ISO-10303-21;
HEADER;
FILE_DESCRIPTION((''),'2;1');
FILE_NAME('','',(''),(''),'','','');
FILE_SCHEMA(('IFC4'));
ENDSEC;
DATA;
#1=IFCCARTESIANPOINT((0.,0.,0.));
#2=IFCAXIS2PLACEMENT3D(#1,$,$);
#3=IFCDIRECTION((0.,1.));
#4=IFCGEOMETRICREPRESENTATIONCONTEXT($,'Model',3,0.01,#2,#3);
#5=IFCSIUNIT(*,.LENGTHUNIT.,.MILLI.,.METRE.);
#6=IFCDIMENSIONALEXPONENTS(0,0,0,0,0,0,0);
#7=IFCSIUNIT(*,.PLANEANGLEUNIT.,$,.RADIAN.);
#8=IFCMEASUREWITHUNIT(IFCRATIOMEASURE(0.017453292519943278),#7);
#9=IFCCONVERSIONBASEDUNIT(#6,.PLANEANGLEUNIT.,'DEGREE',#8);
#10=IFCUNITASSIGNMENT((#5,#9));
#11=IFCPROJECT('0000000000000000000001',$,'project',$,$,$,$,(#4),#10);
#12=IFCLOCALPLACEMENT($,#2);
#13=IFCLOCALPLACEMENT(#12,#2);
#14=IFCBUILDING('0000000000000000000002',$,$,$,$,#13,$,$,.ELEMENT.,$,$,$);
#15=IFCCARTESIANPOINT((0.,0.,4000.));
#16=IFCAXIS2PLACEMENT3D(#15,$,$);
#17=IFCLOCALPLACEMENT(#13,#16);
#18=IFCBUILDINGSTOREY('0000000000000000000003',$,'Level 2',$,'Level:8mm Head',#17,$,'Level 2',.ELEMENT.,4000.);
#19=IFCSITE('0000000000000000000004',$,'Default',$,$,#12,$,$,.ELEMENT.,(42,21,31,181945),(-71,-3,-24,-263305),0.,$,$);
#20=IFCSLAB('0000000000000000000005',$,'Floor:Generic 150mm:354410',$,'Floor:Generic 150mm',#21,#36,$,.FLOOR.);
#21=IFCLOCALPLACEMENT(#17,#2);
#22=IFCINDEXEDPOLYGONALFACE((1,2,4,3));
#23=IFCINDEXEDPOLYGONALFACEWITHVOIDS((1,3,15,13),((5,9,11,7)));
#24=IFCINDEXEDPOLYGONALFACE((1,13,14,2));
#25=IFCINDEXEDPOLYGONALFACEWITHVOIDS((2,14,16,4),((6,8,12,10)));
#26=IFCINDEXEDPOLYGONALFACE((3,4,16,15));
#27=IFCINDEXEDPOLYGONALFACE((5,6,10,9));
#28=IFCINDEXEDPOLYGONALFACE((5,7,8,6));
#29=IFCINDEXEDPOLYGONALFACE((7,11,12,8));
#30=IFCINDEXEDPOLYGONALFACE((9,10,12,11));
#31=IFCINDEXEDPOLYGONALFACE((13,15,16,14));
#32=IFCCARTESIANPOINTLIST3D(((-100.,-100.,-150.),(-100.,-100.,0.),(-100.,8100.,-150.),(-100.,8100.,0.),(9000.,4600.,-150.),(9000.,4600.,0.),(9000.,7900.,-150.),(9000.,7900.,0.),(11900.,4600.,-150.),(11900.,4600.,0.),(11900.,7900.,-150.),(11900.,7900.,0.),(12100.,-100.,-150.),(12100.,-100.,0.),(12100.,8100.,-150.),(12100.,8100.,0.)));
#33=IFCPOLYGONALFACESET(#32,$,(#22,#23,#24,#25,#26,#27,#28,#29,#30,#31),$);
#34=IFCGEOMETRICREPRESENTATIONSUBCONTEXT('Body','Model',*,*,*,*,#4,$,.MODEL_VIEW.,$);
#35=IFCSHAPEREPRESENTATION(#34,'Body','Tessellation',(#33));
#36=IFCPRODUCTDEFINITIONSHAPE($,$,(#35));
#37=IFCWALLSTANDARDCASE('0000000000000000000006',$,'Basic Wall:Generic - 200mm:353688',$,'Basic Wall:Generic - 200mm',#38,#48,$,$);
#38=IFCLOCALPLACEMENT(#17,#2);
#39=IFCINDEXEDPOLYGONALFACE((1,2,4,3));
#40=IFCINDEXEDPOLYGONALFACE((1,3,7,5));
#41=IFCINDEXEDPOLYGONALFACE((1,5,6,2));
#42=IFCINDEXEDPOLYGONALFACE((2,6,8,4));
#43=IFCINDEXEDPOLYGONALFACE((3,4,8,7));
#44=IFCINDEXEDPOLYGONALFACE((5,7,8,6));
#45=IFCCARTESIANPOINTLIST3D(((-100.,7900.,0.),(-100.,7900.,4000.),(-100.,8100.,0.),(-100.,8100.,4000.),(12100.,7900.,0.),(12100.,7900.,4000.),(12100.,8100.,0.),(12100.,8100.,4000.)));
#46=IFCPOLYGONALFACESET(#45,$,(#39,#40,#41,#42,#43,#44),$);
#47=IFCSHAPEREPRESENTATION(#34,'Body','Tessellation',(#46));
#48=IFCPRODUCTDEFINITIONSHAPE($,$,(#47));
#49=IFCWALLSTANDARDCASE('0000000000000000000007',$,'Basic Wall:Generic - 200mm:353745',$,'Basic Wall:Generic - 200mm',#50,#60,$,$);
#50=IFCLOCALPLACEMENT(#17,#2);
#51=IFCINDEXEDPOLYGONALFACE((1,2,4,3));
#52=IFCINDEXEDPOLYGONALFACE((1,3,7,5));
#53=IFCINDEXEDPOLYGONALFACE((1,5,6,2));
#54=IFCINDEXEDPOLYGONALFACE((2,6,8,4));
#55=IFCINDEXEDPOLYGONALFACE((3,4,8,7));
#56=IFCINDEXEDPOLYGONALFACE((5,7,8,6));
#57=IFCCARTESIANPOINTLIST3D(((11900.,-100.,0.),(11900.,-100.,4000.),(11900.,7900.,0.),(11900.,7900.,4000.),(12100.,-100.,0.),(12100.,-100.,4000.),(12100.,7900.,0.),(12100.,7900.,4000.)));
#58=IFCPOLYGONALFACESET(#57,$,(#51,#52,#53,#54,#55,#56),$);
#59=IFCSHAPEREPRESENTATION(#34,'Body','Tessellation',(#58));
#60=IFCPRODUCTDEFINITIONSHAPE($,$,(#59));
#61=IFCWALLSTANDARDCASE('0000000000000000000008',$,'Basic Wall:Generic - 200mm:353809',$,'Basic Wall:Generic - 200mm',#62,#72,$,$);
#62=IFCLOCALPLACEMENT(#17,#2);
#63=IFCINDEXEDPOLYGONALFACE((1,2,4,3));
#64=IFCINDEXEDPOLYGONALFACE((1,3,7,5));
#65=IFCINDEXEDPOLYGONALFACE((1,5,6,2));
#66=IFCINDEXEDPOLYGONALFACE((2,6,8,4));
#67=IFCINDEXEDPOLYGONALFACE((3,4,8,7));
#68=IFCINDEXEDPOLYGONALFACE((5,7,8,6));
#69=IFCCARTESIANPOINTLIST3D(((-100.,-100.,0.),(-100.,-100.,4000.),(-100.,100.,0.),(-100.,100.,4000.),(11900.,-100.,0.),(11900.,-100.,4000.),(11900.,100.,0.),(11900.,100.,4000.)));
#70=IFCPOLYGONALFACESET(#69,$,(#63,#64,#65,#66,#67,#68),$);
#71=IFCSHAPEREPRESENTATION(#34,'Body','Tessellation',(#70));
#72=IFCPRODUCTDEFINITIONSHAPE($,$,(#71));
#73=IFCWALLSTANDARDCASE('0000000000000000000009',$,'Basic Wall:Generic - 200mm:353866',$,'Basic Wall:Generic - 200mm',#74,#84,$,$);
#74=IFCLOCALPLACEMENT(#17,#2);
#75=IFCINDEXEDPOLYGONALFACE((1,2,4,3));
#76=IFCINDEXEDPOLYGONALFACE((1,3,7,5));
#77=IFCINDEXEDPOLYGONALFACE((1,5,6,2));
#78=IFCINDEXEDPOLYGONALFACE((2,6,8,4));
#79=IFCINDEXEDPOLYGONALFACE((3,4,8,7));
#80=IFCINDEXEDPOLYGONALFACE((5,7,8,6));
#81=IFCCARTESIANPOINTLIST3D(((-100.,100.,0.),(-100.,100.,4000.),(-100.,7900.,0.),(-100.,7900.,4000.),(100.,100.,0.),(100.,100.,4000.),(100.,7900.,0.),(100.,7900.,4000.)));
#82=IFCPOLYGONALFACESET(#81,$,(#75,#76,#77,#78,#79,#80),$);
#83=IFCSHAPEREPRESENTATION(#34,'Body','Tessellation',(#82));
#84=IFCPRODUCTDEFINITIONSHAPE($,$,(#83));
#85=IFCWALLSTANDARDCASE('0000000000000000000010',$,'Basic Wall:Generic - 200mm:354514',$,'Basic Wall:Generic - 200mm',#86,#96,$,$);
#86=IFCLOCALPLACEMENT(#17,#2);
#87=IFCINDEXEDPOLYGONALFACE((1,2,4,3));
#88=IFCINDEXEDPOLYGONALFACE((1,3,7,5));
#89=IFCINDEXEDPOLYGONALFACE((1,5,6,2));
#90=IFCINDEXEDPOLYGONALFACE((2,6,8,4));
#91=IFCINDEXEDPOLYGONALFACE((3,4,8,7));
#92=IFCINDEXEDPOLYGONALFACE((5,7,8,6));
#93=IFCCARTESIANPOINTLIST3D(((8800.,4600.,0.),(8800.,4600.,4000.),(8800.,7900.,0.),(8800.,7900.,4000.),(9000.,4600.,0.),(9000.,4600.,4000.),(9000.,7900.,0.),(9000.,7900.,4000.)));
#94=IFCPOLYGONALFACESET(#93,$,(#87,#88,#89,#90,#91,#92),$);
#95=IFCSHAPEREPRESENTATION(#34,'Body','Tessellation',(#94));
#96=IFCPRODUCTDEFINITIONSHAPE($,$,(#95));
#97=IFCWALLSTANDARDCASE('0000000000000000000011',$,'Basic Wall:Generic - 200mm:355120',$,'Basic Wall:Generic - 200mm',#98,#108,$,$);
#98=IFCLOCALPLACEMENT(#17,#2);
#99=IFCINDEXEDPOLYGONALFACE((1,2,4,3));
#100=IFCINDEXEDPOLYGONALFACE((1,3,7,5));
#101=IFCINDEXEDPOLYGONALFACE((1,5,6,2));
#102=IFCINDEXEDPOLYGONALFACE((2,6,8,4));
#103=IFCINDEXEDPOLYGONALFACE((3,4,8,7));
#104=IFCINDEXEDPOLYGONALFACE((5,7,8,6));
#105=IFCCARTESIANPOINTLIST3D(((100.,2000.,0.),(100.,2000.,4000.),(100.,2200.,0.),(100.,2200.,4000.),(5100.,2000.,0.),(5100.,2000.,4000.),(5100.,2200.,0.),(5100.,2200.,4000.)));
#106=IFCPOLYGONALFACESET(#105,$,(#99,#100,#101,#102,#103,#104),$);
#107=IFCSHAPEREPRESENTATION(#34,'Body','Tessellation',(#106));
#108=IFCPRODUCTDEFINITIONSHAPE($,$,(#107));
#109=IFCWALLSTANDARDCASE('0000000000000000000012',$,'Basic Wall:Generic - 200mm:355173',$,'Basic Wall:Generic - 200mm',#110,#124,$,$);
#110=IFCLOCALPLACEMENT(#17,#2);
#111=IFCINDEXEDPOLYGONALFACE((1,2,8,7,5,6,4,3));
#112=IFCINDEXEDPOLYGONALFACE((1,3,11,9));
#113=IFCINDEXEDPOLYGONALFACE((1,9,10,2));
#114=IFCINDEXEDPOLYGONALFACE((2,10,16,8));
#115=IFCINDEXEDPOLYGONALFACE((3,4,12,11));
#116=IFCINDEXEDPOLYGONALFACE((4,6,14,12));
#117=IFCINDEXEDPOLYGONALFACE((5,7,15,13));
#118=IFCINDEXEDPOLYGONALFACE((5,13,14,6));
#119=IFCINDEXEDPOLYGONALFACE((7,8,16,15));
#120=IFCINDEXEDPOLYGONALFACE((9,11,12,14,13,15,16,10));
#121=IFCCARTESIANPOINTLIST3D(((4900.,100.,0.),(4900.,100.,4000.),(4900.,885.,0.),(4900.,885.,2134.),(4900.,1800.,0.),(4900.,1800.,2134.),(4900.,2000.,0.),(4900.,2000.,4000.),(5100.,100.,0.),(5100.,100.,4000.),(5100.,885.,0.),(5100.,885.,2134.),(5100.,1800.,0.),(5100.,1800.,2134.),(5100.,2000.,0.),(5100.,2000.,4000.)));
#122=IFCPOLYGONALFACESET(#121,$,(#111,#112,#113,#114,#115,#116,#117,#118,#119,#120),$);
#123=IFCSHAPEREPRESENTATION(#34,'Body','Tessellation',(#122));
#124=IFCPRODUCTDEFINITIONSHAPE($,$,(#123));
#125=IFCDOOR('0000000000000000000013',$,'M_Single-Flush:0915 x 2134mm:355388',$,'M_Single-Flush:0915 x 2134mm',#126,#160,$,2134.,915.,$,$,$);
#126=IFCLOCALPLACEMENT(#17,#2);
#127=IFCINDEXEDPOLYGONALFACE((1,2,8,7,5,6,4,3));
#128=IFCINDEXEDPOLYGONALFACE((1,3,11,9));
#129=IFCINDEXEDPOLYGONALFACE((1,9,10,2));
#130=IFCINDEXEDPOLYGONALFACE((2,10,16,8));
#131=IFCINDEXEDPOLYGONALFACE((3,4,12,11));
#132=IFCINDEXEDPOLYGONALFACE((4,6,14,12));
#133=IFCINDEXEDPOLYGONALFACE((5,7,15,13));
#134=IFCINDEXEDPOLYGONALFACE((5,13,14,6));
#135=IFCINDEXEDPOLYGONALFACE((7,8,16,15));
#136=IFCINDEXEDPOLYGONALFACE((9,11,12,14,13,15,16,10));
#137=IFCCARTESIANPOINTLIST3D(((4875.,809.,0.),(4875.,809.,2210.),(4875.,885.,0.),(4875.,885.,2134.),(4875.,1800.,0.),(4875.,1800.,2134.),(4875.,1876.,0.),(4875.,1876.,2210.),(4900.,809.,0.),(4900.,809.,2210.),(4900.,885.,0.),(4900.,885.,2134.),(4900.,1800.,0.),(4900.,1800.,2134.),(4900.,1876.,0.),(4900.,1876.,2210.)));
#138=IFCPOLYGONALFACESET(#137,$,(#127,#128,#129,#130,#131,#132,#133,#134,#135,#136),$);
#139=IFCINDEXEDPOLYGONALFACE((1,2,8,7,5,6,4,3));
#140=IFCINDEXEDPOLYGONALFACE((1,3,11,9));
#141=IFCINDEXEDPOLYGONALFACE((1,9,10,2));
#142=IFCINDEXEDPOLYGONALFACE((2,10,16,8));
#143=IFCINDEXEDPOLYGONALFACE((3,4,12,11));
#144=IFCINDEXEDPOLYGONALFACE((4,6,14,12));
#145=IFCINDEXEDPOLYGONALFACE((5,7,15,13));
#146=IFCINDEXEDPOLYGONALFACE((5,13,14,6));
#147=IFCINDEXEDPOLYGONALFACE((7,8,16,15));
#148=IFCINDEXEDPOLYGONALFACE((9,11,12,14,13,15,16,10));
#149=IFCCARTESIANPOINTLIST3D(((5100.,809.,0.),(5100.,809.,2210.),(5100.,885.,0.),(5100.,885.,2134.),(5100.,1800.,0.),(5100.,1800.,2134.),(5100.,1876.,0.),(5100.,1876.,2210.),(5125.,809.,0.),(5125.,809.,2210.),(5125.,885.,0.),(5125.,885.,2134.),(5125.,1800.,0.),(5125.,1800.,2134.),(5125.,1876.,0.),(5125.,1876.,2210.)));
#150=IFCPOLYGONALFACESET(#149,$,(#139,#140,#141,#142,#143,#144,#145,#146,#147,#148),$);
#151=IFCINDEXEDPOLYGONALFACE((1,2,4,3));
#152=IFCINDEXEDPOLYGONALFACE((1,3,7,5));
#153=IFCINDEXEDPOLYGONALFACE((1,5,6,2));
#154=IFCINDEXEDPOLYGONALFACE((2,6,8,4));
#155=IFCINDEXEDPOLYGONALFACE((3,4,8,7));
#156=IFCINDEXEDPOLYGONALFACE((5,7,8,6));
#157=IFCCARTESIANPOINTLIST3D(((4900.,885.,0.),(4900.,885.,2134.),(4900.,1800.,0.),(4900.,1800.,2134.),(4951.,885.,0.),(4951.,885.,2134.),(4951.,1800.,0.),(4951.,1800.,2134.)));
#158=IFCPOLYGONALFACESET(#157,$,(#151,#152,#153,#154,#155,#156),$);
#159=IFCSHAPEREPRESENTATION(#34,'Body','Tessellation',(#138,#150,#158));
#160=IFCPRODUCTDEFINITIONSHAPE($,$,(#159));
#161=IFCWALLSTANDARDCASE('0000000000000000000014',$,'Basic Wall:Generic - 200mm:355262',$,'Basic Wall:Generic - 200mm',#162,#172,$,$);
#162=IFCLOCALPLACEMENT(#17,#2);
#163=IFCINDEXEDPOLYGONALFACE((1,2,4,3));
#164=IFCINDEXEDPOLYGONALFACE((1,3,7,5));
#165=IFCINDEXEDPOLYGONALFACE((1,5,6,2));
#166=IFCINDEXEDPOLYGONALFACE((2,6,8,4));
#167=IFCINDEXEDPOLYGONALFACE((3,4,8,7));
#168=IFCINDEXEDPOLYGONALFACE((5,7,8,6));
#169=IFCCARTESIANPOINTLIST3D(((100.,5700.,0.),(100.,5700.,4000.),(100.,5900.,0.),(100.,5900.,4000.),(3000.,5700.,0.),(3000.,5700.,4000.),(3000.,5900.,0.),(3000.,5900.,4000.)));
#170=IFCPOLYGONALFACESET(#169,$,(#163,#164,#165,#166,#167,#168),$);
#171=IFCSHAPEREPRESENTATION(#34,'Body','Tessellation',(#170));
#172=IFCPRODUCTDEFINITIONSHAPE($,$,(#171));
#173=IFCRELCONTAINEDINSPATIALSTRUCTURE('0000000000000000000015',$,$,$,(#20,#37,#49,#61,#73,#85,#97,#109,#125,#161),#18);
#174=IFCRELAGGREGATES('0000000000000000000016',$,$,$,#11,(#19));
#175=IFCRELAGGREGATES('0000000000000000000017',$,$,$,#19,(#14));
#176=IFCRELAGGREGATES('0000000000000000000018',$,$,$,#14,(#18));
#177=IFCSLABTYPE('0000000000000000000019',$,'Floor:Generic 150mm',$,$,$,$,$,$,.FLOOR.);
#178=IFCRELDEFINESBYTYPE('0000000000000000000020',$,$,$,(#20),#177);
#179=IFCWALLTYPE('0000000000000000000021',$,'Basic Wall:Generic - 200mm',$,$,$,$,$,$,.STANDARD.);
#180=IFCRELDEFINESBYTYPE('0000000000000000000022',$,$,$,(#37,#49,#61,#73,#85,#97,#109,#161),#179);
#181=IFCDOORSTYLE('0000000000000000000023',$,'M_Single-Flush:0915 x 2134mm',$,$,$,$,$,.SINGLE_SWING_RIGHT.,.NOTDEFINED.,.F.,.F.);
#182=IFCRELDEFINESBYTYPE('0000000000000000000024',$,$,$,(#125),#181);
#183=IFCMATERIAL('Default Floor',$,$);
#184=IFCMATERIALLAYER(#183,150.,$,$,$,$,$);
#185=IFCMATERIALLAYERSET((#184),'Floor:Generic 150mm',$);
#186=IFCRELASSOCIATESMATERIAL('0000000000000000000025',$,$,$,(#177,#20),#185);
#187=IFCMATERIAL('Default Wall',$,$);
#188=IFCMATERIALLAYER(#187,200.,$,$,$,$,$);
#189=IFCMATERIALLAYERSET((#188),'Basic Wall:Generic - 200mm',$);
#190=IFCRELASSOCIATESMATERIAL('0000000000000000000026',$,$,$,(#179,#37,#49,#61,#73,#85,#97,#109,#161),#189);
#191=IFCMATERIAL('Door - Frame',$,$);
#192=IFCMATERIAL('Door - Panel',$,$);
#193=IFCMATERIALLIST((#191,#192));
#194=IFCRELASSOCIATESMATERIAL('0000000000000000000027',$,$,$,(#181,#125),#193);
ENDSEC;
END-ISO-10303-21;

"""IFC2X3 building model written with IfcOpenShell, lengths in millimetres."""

from ifc_helpers import new_model, entity, si_unit, converted_unit, direction, frame, frame_2d, origin, place, context, subcontext, project, spatial, polyline, rectangle, outline, extrude, source, transform, mapped, material, material_list, layer, layer_set, layer_usage, type_object, type_shapes, element, fill, save


model = new_model("IFC2X3")

# Units and contexts
model_context = context("Model", 3, precision=0.01, world=origin(), true_north=direction((0.0, 1.0)))
body_context = subcontext(model_context, "Body", "Model", "MODEL_VIEW")
ifc_project = project(units=[si_unit("LENGTHUNIT", "METRE", prefix="MILLI"), converted_unit("PLANEANGLEUNIT", "DEGREE", entity("IfcRatioMeasure", 0.017453292519943278), si_unit("PLANEANGLEUNIT", "RADIAN"), dimensions=[0, 0, 0, 0, 0, 0, 0])], contexts=[model_context])

# Site, building, storey
site_placement = place(None, origin())
site = spatial("IfcSite", under=ifc_project, at=site_placement, Name="Default", CompositionType="ELEMENT", RefLatitude=(42, 21, 31, 181945), RefLongitude=(-71, -3, -24, -263305), RefElevation=0.0)
building_placement = place(site_placement, origin())
building = spatial("IfcBuilding", under=site, at=building_placement, CompositionType="ELEMENT")
storey_placement = place(building_placement, frame((0.0, 0.0, 4000.0)))
storey = spatial("IfcBuildingStorey", under=building, at=storey_placement, Name="Level 2", ObjectType="Level:8mm Head", LongName="Level 2", CompositionType="ELEMENT", Elevation=4000.0)

# Slab, opening
ifc_material_1 = material(Name="Default Floor")
ifc_layer_1 = layer(ifc_material_1, 150.0)
ifc_layer_set_1 = layer_set([ifc_layer_1], Name="Floor:Generic 150mm")
ifc_layer_usage_1 = layer_usage(ifc_layer_set_1, "AXIS3", "POSITIVE", 0.0)
slab_type = type_object("IfcSlabType", Name="Floor:Generic 150mm", PredefinedType="FLOOR", material=ifc_layer_set_1)
slab_placement = place(storey_placement, frame((-100.0, -100.0, -150.0)))
slab = element("IfcSlab", 1, at=slab_placement, inside=storey, type_object=slab_type, material=ifc_layer_usage_1, Name="Floor:Generic 150mm:354410", ObjectType="Floor:Generic 150mm", PredefinedType="FLOOR", context=body_context, shape_type="SweptSolid", body=[
    extrude(rectangle(XDim=8200.0, YDim=12200.0, at=frame_2d((0.0, 0.0), x_axis=(0.0, -1.0))), frame((6100.0, 4100.0, 150.0), z_axis=(0.0, 0.0, -1.0), x_axis=(-1.0, 0.0, 0.0)), (0.0, 0.0, 1.0), 150.0),
])
opening_1_placement = place(slab_placement, origin())
element("IfcOpeningElement", 2, at=opening_1_placement, cuts=slab, ObjectType="Opening", context=body_context, shape_type="SweptSolid", body=[
    extrude(rectangle(XDim=3300.0, YDim=2900.0, at=frame_2d((0.0, 0.0), x_axis=(1.0, 0.0))), frame((10550.0, 6350.0, 150.0), z_axis=(0.0, 0.0, -1.0), x_axis=(0.0, -1.0, 0.0)), (0.0, 0.0, 1.0), 150.0),
])

# Walls
ifc_material_2 = material(Name="Default Wall")
ifc_layer_2 = layer(ifc_material_2, 200.0)
ifc_layer_set_2 = layer_set([ifc_layer_2], Name="Basic Wall:Generic - 200mm")
ifc_layer_usage_2 = layer_usage(ifc_layer_set_2, "AXIS2", "NEGATIVE", 100.0)
wall_type = type_object("IfcWallType", Name="Basic Wall:Generic - 200mm", PredefinedType="STANDARD", material=ifc_layer_set_2)
wall_1_placement = place(storey_placement, frame((-100.0, 8000.0, 0.0)))
element("IfcWallStandardCase", 3, at=wall_1_placement, inside=storey, type_object=wall_type, material=ifc_layer_usage_2, Name="Basic Wall:Generic - 200mm:353688", ObjectType="Basic Wall:Generic - 200mm", context=body_context, shape_type="SweptSolid", body=[
    extrude(rectangle(XDim=12200.0, YDim=200.0, at=frame_2d((6100.0, 0.0), x_axis=(-1.0, 0.0))), origin(), (0.0, 0.0, 1.0), 4000.0),
])
wall_2_placement = place(storey_placement, frame((12000.0, 7900.0, 0.0), z_axis=(0.0, 0.0, 1.0), x_axis=(0.0, -1.0, 0.0)))
element("IfcWallStandardCase", 4, at=wall_2_placement, inside=storey, type_object=wall_type, material=ifc_layer_usage_2, Name="Basic Wall:Generic - 200mm:353745", ObjectType="Basic Wall:Generic - 200mm", context=body_context, shape_type="SweptSolid", body=[
    extrude(rectangle(XDim=8000.0, YDim=200.0, at=frame_2d((4000.0, 0.0), x_axis=(-1.0, 0.0))), origin(), (0.0, 0.0, 1.0), 4000.0),
])
wall_3_placement = place(storey_placement, frame((11900.0, 0.0, 0.0), z_axis=(0.0, 0.0, 1.0), x_axis=(-1.0, 0.0, 0.0)))
element("IfcWallStandardCase", 5, at=wall_3_placement, inside=storey, type_object=wall_type, material=ifc_layer_usage_2, Name="Basic Wall:Generic - 200mm:353809", ObjectType="Basic Wall:Generic - 200mm", context=body_context, shape_type="SweptSolid", body=[
    extrude(rectangle(XDim=12000.0, YDim=200.0, at=frame_2d((6000.0, 0.0), x_axis=(-1.0, 0.0))), origin(), (0.0, 0.0, 1.0), 4000.0),
])
wall_4_placement = place(storey_placement, frame((0.0, 100.0, 0.0), z_axis=(0.0, 0.0, 1.0), x_axis=(0.0, 1.0, 0.0)))
element("IfcWallStandardCase", 6, at=wall_4_placement, inside=storey, type_object=wall_type, material=ifc_layer_usage_2, Name="Basic Wall:Generic - 200mm:353866", ObjectType="Basic Wall:Generic - 200mm", context=body_context, shape_type="SweptSolid", body=[
    extrude(rectangle(XDim=7800.0, YDim=200.0, at=frame_2d((3900.0, 0.0), x_axis=(-1.0, 0.0))), origin(), (0.0, 0.0, 1.0), 4000.0),
])
wall_5_placement = place(storey_placement, frame((8900.0, 7900.0, 0.0), z_axis=(0.0, 0.0, 1.0), x_axis=(0.0, -1.0, 0.0)))
element("IfcWallStandardCase", 7, at=wall_5_placement, inside=storey, type_object=wall_type, material=ifc_layer_usage_2, Name="Basic Wall:Generic - 200mm:354514", ObjectType="Basic Wall:Generic - 200mm", context=body_context, shape_type="SweptSolid", body=[
    extrude(rectangle(XDim=3300.0, YDim=200.0, at=frame_2d((1650.0, 0.0), x_axis=(-1.0, 0.0))), origin(), (0.0, 0.0, 1.0), 4000.0),
])
wall_6_placement = place(storey_placement, frame((100.0, 2100.0, 0.0)))
element("IfcWallStandardCase", 8, at=wall_6_placement, inside=storey, type_object=wall_type, material=ifc_layer_usage_2, Name="Basic Wall:Generic - 200mm:355120", ObjectType="Basic Wall:Generic - 200mm", context=body_context, shape_type="SweptSolid", body=[
    extrude(rectangle(XDim=5000.0, YDim=200.0, at=frame_2d((2500.0, 0.0), x_axis=(-1.0, 0.0))), origin(), (0.0, 0.0, 1.0), 4000.0),
])

# Wall, opening, door
wall_7_placement = place(storey_placement, frame((5000.0, 2000.0, 0.0), z_axis=(0.0, 0.0, 1.0), x_axis=(0.0, -1.0, 0.0)))
wall_7 = element("IfcWallStandardCase", 9, at=wall_7_placement, inside=storey, type_object=wall_type, material=ifc_layer_usage_2, Name="Basic Wall:Generic - 200mm:355173", ObjectType="Basic Wall:Generic - 200mm", context=body_context, shape_type="SweptSolid", body=[
    extrude(rectangle(XDim=1900.0, YDim=200.0, at=frame_2d((950.0, 0.0), x_axis=(1.0, 0.0))), origin(), (0.0, 0.0, 1.0), 4000.0),
])
opening_2_placement = place(wall_7_placement, frame((1115.0, 100.0, 0.0)))
opening_2 = element("IfcOpeningElement", 10, at=opening_2_placement, cuts=wall_7, ObjectType="Opening", context=body_context, shape_type="SweptSolid", body=[
    extrude(rectangle(XDim=915.0, YDim=2134.0, at=frame_2d((1067.0, 457.5), x_axis=(0.0, 1.0))), frame((0.0, 0.0, 0.0), z_axis=(0.0, -1.0, 0.0), x_axis=(0.0, 0.0, 1.0)), (0.0, 0.0, 1.0), 200.0),
])
ifc_material_3 = material(Name="Door - Frame")
ifc_material_4 = material(Name="Door - Panel")
ifc_material_list = material_list([ifc_material_3, ifc_material_4])
door_style = type_object("IfcDoorStyle", Name="M_Single-Flush:0915 x 2134mm", ConstructionType="NOTDEFINED", OperationType="SINGLE_SWING_RIGHT", ParameterTakesPrecedence=False, Sizeable=False, material=ifc_material_list)
shared_shape = source(origin(), body_context, "Body", "SweptSolid", [
    extrude(outline(polyline([(-533.5, -1124.0), (533.5, -1124.0), (533.5, 1086.0), (457.5, 1086.0), (457.5, -1048.0), (-457.5, -1048.0), (-457.5, 1086.0), (-533.5, 1086.0), (-533.5, -1124.0)])), frame((457.5, 200.0, 1086.0), z_axis=(0.0, 1.0, 0.0), x_axis=(1.0, 0.0, 0.0)), (0.0, 0.0, 1.0), 25.0),
    extrude(outline(polyline([(-1124.0, -533.5), (1086.0, -533.5), (1086.0, -457.5), (-1048.0, -457.5), (-1048.0, 457.5), (1086.0, 457.5), (1086.0, 533.5), (-1124.0, 533.5), (-1124.0, -533.5)])), frame((457.5, -25.0, 1086.0), z_axis=(0.0, 1.0, 0.0), x_axis=(0.0, 0.0, -1.0)), (0.0, 0.0, 1.0), 25.0),
    extrude(rectangle(XDim=51.0, YDim=915.0, at=frame_2d((0.0, 0.0), x_axis=(1.0, 0.0))), frame((457.5, 174.5, 0.0), z_axis=(0.0, 0.0, 1.0), x_axis=(0.0, 1.0, 0.0)), (0.0, 0.0, 1.0), 2134.0),
])
type_shapes(door_style, [shared_shape])
door_1_placement = place(opening_2_placement, frame((0.0, 0.0, 0.0), z_axis=(0.0, 0.0, 1.0), x_axis=(-1.0, 0.0, 0.0)))
door_1 = element("IfcDoor", 11, at=door_1_placement, inside=storey, type_object=door_style, material=ifc_material_list, Name="M_Single-Flush:0915 x 2134mm:355388", ObjectType="M_Single-Flush:0915 x 2134mm", OverallHeight=2134.0, OverallWidth=915.0, context=body_context, shape_type="MappedRepresentation", body=[
    mapped(shared_shape, transform((0.0, 0.0, 0.0), scale=1.0)),
])
fill(opening_2, door_1)

# Wall
wall_8_placement = place(storey_placement, frame((100.0, 5800.0, 0.0)))
element("IfcWallStandardCase", 12, at=wall_8_placement, inside=storey, type_object=wall_type, material=ifc_layer_usage_2, Name="Basic Wall:Generic - 200mm:355262", ObjectType="Basic Wall:Generic - 200mm", context=body_context, shape_type="SweptSolid", body=[
    extrude(rectangle(XDim=2900.0, YDim=200.0, at=frame_2d((1450.0, 0.0), x_axis=(-1.0, 0.0))), origin(), (0.0, 0.0, 1.0), 4000.0),
])

save(model, "model.ifc")
